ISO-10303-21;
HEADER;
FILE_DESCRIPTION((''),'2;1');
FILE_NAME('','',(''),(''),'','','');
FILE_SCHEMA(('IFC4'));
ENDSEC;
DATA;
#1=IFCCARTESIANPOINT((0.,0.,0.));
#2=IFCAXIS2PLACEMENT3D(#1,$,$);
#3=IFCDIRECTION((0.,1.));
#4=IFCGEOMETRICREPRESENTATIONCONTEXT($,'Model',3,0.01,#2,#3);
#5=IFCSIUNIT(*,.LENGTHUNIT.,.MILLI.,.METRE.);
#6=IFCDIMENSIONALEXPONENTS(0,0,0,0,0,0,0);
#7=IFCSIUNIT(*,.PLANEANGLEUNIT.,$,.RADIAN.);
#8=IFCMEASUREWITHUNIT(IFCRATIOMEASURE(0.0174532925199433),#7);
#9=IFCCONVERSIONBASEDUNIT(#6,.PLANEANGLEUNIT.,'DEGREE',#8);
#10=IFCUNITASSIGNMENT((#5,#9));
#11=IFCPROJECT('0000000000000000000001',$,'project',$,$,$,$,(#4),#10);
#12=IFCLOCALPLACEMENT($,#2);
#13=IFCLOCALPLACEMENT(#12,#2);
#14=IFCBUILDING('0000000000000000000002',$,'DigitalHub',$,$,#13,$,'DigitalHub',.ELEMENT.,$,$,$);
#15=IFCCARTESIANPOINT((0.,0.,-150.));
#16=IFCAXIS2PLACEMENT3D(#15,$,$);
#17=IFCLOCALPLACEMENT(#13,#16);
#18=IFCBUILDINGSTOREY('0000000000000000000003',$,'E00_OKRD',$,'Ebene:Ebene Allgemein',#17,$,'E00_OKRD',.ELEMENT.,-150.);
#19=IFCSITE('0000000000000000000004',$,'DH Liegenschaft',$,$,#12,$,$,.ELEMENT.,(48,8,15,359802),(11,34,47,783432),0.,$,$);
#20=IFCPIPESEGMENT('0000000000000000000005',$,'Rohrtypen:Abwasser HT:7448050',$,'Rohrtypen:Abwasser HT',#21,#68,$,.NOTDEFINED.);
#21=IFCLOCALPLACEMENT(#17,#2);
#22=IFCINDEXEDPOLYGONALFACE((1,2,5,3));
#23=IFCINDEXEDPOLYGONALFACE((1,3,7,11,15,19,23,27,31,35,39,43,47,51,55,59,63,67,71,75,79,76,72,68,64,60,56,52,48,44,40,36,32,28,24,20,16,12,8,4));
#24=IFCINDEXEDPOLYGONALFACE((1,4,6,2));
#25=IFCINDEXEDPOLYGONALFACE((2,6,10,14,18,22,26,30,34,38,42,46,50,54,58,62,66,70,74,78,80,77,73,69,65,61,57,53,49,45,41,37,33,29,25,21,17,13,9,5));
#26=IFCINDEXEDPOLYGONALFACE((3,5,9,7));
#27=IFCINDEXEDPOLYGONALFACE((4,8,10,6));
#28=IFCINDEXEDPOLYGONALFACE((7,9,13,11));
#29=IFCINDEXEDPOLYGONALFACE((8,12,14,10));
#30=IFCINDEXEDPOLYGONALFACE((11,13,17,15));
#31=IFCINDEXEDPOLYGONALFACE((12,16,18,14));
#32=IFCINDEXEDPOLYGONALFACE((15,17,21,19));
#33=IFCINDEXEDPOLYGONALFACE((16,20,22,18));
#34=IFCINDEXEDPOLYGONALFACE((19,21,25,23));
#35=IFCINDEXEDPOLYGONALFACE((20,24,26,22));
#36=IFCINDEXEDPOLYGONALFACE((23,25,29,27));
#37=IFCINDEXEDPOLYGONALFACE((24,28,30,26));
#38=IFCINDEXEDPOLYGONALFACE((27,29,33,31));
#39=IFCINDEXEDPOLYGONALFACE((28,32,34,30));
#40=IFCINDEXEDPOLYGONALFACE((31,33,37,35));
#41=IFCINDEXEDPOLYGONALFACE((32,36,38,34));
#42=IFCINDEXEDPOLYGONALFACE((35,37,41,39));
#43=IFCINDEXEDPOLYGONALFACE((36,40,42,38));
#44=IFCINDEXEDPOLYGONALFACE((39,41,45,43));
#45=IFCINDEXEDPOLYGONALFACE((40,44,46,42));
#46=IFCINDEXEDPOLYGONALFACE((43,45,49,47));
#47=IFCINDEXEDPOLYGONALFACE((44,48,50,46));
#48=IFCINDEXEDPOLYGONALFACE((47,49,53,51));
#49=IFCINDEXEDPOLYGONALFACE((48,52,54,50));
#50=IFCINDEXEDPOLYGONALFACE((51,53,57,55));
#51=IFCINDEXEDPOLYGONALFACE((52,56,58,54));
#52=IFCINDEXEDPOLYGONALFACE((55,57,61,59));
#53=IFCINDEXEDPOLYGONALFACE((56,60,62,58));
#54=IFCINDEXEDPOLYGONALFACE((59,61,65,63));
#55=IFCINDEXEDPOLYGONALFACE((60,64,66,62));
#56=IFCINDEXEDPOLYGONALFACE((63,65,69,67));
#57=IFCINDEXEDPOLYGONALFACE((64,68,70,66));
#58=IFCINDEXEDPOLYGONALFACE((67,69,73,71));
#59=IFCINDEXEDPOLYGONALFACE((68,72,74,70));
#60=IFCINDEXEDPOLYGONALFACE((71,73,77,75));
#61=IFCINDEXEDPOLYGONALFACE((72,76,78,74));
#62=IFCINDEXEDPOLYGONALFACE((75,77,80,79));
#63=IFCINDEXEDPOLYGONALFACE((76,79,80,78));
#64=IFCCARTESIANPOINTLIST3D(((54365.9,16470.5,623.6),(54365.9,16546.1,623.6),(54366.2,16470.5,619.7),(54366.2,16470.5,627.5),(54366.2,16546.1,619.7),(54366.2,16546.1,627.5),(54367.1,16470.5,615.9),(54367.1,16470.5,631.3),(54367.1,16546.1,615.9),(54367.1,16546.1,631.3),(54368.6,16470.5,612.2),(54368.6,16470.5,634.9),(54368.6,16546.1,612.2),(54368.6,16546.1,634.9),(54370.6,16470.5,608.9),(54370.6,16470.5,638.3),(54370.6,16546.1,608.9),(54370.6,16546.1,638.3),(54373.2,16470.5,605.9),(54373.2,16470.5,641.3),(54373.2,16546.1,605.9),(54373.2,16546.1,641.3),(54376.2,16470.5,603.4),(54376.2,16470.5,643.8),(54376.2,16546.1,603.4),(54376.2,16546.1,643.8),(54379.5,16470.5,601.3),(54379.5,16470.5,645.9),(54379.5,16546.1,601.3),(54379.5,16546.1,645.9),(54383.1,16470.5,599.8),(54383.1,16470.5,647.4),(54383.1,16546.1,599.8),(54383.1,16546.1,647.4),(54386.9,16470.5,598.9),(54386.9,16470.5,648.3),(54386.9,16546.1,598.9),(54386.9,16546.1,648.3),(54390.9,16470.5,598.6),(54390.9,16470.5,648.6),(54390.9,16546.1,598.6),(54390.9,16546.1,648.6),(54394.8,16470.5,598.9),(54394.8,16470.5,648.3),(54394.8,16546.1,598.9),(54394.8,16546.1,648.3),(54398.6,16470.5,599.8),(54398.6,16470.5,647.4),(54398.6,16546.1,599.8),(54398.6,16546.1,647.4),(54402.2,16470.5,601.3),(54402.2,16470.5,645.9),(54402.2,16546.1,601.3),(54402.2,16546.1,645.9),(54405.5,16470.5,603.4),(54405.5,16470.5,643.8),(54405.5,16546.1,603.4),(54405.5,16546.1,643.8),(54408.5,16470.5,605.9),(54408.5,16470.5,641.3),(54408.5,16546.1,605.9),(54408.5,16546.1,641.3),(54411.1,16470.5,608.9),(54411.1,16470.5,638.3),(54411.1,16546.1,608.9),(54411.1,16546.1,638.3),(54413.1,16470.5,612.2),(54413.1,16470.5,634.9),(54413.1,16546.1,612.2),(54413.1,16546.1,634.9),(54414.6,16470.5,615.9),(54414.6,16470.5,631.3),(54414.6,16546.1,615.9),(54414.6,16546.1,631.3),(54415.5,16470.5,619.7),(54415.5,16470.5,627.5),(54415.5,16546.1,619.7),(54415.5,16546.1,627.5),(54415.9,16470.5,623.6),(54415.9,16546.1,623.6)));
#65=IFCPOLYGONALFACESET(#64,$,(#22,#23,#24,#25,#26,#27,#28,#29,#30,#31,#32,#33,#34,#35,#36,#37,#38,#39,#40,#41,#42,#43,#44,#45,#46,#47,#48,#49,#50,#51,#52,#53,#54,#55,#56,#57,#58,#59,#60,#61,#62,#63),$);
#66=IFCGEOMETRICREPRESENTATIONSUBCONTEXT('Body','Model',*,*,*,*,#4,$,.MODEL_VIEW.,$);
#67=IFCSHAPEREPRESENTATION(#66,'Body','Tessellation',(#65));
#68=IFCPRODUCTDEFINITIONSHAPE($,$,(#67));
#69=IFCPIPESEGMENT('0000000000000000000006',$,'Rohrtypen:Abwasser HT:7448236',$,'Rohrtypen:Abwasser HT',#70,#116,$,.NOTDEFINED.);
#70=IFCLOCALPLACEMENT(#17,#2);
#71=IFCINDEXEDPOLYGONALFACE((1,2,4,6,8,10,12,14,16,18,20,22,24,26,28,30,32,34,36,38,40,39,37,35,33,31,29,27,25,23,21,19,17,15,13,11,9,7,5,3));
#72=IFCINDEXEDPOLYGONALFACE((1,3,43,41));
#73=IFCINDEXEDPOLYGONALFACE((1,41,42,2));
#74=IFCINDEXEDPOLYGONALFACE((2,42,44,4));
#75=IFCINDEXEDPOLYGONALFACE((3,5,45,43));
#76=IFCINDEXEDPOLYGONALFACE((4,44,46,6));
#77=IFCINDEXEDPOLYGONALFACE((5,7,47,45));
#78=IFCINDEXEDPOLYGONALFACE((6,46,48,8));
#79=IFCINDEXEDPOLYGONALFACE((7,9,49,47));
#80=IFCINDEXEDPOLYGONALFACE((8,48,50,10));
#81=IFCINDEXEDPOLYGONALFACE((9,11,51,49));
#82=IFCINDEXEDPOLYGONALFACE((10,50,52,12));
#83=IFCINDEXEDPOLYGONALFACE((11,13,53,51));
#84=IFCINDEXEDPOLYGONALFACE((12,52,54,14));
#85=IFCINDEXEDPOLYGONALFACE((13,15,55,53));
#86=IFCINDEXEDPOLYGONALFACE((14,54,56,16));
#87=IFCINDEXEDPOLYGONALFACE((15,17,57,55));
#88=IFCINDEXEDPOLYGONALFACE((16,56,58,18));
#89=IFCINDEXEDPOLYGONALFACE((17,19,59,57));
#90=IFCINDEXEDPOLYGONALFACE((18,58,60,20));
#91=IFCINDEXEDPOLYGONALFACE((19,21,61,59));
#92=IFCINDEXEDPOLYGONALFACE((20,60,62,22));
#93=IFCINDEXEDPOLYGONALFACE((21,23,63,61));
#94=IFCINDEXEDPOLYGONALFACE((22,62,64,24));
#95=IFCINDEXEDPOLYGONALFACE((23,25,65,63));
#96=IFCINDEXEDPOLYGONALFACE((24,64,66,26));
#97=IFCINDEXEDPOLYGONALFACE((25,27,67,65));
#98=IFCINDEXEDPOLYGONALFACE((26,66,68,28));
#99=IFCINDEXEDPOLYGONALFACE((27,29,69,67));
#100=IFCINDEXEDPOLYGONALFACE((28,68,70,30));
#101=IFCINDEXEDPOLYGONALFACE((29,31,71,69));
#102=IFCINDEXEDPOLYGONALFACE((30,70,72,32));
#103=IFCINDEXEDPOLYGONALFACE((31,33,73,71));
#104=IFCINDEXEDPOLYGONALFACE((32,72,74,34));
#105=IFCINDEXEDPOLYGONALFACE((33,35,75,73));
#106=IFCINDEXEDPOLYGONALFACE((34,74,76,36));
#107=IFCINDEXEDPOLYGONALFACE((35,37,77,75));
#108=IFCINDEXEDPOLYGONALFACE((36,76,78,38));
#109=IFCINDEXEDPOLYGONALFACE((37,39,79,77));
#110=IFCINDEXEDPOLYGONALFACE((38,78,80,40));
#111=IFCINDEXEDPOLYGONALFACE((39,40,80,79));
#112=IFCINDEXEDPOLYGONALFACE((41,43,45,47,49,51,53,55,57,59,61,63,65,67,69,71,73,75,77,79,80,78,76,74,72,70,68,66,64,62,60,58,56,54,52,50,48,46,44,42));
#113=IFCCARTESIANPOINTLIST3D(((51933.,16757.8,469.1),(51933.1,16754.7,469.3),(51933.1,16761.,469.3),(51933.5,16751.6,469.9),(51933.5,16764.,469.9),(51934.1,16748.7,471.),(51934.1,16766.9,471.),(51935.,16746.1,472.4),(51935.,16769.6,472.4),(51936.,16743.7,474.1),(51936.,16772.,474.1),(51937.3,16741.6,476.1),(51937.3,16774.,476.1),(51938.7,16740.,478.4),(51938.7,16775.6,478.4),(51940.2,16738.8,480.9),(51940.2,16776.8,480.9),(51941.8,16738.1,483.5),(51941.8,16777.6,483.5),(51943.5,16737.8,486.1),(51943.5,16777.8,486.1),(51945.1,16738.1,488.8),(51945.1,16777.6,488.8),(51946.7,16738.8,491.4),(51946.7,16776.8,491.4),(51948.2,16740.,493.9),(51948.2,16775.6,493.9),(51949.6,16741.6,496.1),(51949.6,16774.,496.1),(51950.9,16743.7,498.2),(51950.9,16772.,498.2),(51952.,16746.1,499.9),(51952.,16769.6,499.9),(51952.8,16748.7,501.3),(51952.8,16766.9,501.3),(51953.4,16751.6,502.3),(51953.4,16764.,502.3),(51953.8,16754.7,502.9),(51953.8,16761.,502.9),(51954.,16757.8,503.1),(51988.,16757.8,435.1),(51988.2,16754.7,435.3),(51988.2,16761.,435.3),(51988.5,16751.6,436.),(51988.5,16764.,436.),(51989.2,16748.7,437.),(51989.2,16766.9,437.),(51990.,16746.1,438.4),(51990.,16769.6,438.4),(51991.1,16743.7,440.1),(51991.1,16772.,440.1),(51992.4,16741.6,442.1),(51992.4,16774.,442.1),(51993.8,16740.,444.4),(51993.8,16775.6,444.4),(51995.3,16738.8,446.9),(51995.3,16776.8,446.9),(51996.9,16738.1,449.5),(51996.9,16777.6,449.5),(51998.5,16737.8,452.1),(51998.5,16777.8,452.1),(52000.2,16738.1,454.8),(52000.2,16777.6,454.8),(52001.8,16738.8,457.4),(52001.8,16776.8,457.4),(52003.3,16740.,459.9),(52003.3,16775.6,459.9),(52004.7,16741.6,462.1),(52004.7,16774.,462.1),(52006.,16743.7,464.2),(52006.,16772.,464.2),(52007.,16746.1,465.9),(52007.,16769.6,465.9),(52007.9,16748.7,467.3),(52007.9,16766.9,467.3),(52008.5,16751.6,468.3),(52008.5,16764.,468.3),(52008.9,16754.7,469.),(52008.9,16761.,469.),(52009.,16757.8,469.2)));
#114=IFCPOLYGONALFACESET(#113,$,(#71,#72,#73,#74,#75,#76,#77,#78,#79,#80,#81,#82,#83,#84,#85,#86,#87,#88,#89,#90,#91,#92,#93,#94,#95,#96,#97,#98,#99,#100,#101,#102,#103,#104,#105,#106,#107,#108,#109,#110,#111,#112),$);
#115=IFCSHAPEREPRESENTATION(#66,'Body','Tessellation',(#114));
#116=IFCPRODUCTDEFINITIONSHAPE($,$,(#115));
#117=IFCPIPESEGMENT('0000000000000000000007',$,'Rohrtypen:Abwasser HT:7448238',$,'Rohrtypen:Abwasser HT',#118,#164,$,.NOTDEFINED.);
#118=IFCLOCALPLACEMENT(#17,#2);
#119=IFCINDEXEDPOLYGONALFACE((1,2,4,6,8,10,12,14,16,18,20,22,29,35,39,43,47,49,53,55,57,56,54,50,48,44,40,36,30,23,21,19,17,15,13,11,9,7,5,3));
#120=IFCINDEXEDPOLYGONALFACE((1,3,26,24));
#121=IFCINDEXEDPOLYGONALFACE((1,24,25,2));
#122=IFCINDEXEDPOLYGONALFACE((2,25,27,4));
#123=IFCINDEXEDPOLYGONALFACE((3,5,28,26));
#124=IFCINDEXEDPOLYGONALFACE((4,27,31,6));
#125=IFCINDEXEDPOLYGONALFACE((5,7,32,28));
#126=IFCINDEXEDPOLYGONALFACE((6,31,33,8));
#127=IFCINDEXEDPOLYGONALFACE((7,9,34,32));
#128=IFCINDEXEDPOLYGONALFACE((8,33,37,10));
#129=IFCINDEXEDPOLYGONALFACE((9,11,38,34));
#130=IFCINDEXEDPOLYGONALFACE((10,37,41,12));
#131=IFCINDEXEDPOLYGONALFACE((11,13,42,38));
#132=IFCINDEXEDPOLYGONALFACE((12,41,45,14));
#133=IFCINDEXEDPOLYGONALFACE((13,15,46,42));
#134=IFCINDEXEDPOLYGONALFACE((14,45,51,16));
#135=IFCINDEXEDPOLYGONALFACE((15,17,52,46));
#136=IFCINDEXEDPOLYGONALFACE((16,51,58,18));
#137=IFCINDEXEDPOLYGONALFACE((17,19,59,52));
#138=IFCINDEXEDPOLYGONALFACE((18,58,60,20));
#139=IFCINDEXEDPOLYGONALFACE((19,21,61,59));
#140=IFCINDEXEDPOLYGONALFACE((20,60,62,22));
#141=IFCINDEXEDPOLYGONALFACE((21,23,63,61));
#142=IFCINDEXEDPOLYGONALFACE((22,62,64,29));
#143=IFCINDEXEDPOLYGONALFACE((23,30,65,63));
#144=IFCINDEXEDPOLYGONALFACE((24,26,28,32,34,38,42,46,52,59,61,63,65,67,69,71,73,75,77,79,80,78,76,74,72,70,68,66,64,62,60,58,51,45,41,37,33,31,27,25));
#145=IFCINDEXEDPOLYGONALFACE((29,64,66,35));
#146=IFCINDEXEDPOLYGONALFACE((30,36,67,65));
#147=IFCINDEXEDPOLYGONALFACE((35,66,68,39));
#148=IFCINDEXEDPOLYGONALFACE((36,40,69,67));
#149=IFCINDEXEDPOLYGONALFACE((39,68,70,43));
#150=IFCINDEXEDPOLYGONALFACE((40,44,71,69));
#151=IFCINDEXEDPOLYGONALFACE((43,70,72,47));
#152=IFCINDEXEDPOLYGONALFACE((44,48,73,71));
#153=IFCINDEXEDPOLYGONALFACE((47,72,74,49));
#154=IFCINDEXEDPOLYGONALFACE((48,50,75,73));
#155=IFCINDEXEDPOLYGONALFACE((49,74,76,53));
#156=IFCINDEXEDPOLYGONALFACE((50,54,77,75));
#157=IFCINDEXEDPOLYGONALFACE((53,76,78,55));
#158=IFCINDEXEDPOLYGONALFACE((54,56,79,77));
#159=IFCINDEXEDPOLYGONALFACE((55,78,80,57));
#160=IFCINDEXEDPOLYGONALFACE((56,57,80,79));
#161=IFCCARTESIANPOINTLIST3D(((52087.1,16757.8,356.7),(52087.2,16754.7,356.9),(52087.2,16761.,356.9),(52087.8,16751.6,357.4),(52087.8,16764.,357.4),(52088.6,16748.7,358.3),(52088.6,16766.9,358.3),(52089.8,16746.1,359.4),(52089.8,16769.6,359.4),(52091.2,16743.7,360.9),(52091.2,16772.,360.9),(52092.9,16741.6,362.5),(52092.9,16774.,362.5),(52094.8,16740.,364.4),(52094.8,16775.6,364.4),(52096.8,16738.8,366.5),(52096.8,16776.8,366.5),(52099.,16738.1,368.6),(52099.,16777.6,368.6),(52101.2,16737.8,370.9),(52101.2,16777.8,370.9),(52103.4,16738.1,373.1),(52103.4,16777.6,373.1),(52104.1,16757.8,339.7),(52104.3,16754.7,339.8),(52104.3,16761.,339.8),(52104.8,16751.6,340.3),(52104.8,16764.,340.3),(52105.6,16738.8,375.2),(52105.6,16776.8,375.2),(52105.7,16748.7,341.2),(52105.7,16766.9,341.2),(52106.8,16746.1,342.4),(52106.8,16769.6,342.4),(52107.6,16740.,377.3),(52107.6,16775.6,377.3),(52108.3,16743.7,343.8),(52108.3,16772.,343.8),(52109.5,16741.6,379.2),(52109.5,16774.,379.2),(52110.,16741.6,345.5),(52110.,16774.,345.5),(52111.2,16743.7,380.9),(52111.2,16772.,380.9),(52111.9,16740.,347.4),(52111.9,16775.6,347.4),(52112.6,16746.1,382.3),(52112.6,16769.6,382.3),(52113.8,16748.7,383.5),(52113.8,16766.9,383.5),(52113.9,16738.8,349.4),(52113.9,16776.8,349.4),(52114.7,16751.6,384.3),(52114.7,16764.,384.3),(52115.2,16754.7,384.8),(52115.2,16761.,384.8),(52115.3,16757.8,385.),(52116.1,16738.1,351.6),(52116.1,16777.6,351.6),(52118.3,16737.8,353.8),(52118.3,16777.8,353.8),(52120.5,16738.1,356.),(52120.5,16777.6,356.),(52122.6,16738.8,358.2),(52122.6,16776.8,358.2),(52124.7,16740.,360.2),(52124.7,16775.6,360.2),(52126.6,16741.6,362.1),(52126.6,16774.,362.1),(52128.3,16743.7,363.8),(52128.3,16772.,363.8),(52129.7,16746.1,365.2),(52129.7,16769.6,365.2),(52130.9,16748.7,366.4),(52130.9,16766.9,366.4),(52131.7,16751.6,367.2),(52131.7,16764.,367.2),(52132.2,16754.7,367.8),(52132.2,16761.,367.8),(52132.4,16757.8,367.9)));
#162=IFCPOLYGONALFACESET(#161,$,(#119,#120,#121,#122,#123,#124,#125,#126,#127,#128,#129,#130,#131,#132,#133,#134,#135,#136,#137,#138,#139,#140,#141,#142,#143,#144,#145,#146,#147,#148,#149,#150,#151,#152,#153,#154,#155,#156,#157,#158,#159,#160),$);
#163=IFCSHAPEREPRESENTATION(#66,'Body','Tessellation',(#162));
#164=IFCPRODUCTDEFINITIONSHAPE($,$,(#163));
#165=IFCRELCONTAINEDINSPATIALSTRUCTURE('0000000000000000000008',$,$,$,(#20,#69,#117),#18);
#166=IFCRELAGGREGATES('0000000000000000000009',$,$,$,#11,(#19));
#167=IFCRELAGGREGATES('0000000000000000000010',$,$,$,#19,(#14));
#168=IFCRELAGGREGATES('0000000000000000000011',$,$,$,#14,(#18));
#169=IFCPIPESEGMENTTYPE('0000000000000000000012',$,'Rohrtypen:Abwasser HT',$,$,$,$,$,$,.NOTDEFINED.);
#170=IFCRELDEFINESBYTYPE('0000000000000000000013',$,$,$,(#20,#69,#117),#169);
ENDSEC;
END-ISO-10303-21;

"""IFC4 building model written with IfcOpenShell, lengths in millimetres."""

from ifc_helpers import new_model, entity, si_unit, converted_unit, direction, frame, origin, place, context, subcontext, project, spatial, indexed_curve, outline, extrude, type_object, element, save


model = new_model("IFC4")

# Units and contexts
model_context = context("Model", 3, precision=0.01, world=origin(), true_north=direction((0.0, 1.0)))
body_context = subcontext(model_context, "Body", "Model", "MODEL_VIEW")
ifc_project = project(units=[si_unit("LENGTHUNIT", "METRE", prefix="MILLI"), converted_unit("PLANEANGLEUNIT", "DEGREE", entity("IfcRatioMeasure", 0.0174532925199433), si_unit("PLANEANGLEUNIT", "RADIAN"), dimensions=[0, 0, 0, 0, 0, 0, 0])], contexts=[model_context])

# Site, building, storey
site_placement = place(None, origin())
site = spatial("IfcSite", under=ifc_project, at=site_placement, Name="DH Liegenschaft", CompositionType="ELEMENT", RefLatitude=(48, 8, 15, 359802), RefLongitude=(11, 34, 47, 783432), RefElevation=0.0)
building_placement = place(site_placement, origin())
building = spatial("IfcBuilding", under=site, at=building_placement, Name="DigitalHub", LongName="DigitalHub", CompositionType="ELEMENT")
storey_placement = place(building_placement, frame((0.0, 0.0, -150.0)))
storey = spatial("IfcBuildingStorey", under=building, at=storey_placement, Name="E00_OKRD", ObjectType="Ebene:Ebene Allgemein", LongName="E00_OKRD", CompositionType="ELEMENT", Elevation=-150.0)

# Pipe segments
pipe_segment_type_1 = type_object("IfcPipeSegmentType", Name="Rohrtypen:Abwasser HT", PredefinedType="NOTDEFINED")
pipe_segment_1_placement = place(storey_placement, frame((54364.3, 16470.5, 597.0)))
element("IfcPipeSegment", 1, at=pipe_segment_1_placement, inside=storey, type_object=pipe_segment_type_1, Name="Rohrtypen:Abwasser HT:7448050", ObjectType="Rohrtypen:Abwasser HT", PredefinedType="NOTDEFINED", context=body_context, shape_type="SweptSolid", body=[
    extrude(outline(indexed_curve([(25.0, 0.0), (24.7, 3.9), (23.8, 7.7), (22.3, 11.3), (20.2, 14.7), (17.7, 17.7), (14.7, 20.2), (11.3, 22.3), (7.7, 23.8), (3.9, 24.7), (0.0, 25.0), (-3.9, 24.7), (-7.7, 23.8), (-11.3, 22.3), (-14.7, 20.2), (-17.7, 17.7), (-20.2, 14.7), (-22.3, 11.3), (-23.8, 7.7), (-24.7, 3.9), (-25.0, 0.0), (-24.7, -3.9), (-23.8, -7.7), (-22.3, -11.3), (-20.2, -14.7), (-17.7, -17.7), (-14.7, -20.2), (-11.3, -22.3), (-7.7, -23.8), (-3.9, -24.7), (0.0, -25.0), (3.9, -24.7), (7.7, -23.8), (11.3, -22.3), (14.7, -20.2), (17.7, -17.7), (20.2, -14.7), (22.3, -11.3), (23.8, -7.7), (24.7, -3.9), (25.0, 0.0)], self_intersect=False)), frame((26.6, 0.0, 26.6), z_axis=(0.0, 1.0, 0.0), x_axis=(1.0, 0.0, 0.0)), (0.0, 0.0, 1.0), 75.6),
])
pipe_segment_2_placement = place(storey_placement, frame((51931.4, 16736.2, 433.5)))
element("IfcPipeSegment", 2, at=pipe_segment_2_placement, inside=storey, type_object=pipe_segment_type_1, Name="Rohrtypen:Abwasser HT:7448236", ObjectType="Rohrtypen:Abwasser HT", PredefinedType="NOTDEFINED", context=body_context, shape_type="SweptSolid", body=[
    extrude(outline(indexed_curve([(20.0, 0.0), (19.8, 3.1), (19.0, 6.2), (17.8, 9.1), (16.2, 11.8), (14.1, 14.1), (11.8, 16.2), (9.1, 17.8), (6.2, 19.0), (3.1, 19.8), (0.0, 20.0), (-3.1, 19.8), (-6.2, 19.0), (-9.1, 17.8), (-11.8, 16.2), (-14.1, 14.1), (-16.2, 11.8), (-17.8, 9.1), (-19.0, 6.2), (-19.8, 3.1), (-20.0, 0.0), (-19.8, -3.1), (-19.0, -6.2), (-17.8, -9.1), (-16.2, -11.8), (-14.1, -14.1), (-11.8, -16.2), (-9.1, -17.8), (-6.2, -19.0), (-3.1, -19.8), (0.0, -20.0), (3.1, -19.8), (6.2, -19.0), (9.1, -17.8), (11.8, -16.2), (14.1, -14.1), (16.2, -11.8), (17.8, -9.1), (19.0, -6.2), (19.8, -3.1), (20.0, 0.0)], self_intersect=False)), frame((67.2, 21.6, 18.6), z_axis=(-0.851013, 0.0, 0.525145), x_axis=(0.0, -1.0, 0.0)), (0.0, 0.0, 1.0), 64.7),
])
pipe_segment_3_placement = place(storey_placement, frame((52085.5, 16736.2, 338.1)))
element("IfcPipeSegment", 3, at=pipe_segment_3_placement, inside=storey, type_object=pipe_segment_type_1, Name="Rohrtypen:Abwasser HT:7448238", ObjectType="Rohrtypen:Abwasser HT", PredefinedType="NOTDEFINED", context=body_context, shape_type="SweptSolid", body=[
    extrude(outline(indexed_curve([(20.0, 0.0), (19.8, 3.1), (19.0, 6.2), (17.8, 9.1), (16.2, 11.8), (14.1, 14.1), (11.8, 16.2), (9.1, 17.8), (6.2, 19.0), (3.1, 19.8), (0.0, 20.0), (-3.1, 19.8), (-6.2, 19.0), (-9.1, 17.8), (-11.8, 16.2), (-14.1, 14.1), (-16.2, 11.8), (-17.8, 9.1), (-19.0, 6.2), (-19.8, 3.1), (-20.0, 0.0), (-19.8, -3.1), (-19.0, -6.2), (-17.8, -9.1), (-16.2, -11.8), (-14.1, -14.1), (-11.8, -16.2), (-9.1, -17.8), (-6.2, -19.0), (-3.1, -19.8), (0.0, -20.0), (3.1, -19.8), (6.2, -19.0), (9.1, -17.8), (11.8, -16.2), (14.1, -14.1), (16.2, -11.8), (17.8, -9.1), (19.0, -6.2), (19.8, -3.1), (20.0, 0.0)], self_intersect=False)), frame((15.7, 21.6, 32.8), z_axis=(0.707107, 0.0, -0.707107), x_axis=(0.0, 1.0, 0.0)), (0.0, 0.0, 1.0), 24.1),
])

save(model, "model.ifc")
